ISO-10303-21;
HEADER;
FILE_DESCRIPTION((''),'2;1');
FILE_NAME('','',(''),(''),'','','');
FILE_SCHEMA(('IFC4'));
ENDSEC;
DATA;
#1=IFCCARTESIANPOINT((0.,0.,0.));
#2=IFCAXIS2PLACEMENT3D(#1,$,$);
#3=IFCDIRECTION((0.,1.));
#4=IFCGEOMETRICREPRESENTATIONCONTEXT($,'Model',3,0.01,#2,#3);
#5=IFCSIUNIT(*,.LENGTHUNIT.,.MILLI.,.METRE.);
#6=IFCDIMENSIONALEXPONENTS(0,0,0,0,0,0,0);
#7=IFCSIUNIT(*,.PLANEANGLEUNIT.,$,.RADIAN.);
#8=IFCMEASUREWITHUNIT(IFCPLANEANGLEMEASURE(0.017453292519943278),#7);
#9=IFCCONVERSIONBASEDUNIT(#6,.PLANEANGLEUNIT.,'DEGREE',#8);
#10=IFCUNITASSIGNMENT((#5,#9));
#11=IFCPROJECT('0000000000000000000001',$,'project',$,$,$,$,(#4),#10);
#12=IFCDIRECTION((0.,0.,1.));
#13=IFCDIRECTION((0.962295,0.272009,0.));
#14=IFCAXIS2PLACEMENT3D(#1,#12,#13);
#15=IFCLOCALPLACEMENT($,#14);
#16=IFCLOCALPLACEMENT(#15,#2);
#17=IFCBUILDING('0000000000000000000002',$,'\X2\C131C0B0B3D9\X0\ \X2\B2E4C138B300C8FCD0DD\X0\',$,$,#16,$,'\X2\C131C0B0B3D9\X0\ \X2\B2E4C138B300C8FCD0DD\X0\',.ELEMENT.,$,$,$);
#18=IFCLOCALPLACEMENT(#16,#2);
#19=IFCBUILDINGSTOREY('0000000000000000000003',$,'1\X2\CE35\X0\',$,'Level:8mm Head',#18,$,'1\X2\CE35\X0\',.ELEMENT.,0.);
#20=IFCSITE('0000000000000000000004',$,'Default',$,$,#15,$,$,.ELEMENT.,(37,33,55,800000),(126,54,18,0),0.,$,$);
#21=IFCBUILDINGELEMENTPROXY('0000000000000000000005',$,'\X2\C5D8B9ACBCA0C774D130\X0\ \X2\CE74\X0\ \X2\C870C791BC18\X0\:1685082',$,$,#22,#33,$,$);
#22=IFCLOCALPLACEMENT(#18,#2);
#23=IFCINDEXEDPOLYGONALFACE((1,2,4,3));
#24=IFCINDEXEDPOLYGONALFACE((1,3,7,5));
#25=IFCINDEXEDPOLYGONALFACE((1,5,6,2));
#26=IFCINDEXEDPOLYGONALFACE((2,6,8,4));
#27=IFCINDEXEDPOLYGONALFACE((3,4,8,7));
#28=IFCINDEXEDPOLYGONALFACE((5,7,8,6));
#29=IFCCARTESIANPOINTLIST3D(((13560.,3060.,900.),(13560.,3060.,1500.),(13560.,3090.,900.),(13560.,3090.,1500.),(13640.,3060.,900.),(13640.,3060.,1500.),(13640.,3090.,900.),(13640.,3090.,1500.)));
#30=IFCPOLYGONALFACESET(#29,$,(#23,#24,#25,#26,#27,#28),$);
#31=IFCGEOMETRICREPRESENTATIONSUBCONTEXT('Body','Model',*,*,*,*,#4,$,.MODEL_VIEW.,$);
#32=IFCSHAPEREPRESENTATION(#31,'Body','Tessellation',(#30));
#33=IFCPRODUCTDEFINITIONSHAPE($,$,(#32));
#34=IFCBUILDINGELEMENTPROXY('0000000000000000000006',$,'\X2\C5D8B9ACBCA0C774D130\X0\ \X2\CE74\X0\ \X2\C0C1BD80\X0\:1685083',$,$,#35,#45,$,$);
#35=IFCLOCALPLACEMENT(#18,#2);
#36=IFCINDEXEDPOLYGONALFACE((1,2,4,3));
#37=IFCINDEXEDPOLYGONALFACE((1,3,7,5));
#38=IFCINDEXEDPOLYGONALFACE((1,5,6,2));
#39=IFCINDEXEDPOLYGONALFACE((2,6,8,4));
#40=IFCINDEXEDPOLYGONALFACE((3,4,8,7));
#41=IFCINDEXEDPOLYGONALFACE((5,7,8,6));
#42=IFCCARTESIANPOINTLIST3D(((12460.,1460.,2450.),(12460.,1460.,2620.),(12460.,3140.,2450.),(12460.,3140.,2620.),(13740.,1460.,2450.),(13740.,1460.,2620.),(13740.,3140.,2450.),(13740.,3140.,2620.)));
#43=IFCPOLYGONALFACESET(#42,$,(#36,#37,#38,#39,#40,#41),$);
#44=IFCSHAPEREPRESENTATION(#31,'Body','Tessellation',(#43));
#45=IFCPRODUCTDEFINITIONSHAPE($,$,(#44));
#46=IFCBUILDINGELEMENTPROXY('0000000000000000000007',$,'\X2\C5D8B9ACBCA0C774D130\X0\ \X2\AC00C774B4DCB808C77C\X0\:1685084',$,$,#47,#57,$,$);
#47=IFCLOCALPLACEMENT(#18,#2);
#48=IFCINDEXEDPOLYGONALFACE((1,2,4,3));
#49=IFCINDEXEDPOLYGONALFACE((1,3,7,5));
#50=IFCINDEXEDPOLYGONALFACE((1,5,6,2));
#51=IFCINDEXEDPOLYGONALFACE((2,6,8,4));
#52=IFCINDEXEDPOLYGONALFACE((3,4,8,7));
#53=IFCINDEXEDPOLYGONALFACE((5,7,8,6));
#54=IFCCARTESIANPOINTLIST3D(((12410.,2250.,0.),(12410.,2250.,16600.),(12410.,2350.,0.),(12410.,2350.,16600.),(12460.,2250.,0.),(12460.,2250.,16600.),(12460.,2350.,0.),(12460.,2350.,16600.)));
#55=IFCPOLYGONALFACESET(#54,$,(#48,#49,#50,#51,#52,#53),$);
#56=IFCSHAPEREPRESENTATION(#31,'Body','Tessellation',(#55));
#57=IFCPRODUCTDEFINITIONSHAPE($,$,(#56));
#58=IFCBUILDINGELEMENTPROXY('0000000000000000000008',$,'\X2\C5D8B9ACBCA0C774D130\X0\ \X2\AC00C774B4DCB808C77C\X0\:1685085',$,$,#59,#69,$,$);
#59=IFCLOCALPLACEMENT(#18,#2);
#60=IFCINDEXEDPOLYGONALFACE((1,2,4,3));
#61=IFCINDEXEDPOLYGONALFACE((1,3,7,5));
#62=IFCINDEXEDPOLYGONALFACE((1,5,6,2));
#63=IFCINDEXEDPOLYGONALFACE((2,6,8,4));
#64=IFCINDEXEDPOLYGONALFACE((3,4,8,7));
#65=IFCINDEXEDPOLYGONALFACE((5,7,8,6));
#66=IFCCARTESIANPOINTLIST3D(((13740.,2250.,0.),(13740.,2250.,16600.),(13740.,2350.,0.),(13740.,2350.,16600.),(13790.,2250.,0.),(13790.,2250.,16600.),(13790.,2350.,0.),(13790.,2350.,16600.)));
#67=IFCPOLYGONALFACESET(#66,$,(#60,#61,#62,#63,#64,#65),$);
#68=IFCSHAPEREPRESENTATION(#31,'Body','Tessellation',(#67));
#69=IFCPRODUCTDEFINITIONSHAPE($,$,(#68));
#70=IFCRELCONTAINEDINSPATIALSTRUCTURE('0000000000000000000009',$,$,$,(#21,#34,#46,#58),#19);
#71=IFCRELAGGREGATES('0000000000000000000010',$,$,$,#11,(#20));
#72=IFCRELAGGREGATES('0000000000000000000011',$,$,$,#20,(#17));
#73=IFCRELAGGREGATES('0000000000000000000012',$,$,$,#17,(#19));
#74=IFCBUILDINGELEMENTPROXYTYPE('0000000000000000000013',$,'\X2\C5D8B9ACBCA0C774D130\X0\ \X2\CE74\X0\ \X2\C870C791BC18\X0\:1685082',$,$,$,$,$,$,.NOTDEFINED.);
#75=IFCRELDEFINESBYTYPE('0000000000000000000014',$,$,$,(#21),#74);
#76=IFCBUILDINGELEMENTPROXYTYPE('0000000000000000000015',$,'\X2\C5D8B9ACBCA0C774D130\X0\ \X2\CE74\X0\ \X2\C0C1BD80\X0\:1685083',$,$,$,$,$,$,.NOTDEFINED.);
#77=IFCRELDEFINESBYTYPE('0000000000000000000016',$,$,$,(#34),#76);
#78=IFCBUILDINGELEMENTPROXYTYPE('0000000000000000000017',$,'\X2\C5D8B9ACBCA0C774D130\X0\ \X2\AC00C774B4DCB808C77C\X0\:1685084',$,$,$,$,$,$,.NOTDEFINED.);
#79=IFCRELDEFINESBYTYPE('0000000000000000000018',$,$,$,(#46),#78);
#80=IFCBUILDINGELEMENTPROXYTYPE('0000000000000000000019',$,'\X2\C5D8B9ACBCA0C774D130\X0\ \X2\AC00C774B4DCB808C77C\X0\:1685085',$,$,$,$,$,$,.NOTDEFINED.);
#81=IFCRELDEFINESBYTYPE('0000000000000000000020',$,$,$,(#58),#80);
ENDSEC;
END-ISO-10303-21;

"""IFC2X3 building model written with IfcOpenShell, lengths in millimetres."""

from ifc_helpers import new_model, entity, si_unit, converted_unit, direction, frame, frame_2d, origin, origin_2d_with_axis, place, context, subcontext, project, spatial, rectangle, extrude, type_object, element, save


model = new_model("IFC2X3")

# Units and contexts
model_context = context("Model", 3, precision=0.01, world=origin(), true_north=direction((0.0, 1.0)))
body_context = subcontext(model_context, "Body", "Model", "MODEL_VIEW")
ifc_project = project(units=[si_unit("LENGTHUNIT", "METRE", prefix="MILLI"), converted_unit("PLANEANGLEUNIT", "DEGREE", entity("IfcPlaneAngleMeasure", 0.017453292519943278), si_unit("PLANEANGLEUNIT", "RADIAN"), dimensions=[0, 0, 0, 0, 0, 0, 0])], contexts=[model_context])

# Site, building, storey
site_placement = place(None, frame((0.0, 0.0, 0.0), z_axis=(0.0, 0.0, 1.0), x_axis=(0.962295, 0.272009, 0.0)))
site = spatial("IfcSite", under=ifc_project, at=site_placement, Name="Default", CompositionType="ELEMENT", RefLatitude=(37, 33, 55, 800000), RefLongitude=(126, 54, 18, 0), RefElevation=0.0)
building_placement = place(site_placement, origin())
building = spatial("IfcBuilding", under=site, at=building_placement, Name="성산동 다세대주택", LongName="성산동 다세대주택", CompositionType="ELEMENT")
storey_placement = place(building_placement, origin())
storey = spatial("IfcBuildingStorey", under=building, at=storey_placement, Name="1층", ObjectType="Level:8mm Head", LongName="1층", CompositionType="ELEMENT", Elevation=0.0)

# Building element proxies
building_element_proxy_type_1 = type_object("IfcBuildingElementProxyType", Name="엘리베이터 카 조작반:1685082", PredefinedType="NOTDEFINED")
proxy_1_placement = place(storey_placement, origin())
element("IfcBuildingElementProxy", 1, at=proxy_1_placement, inside=storey, type_object=building_element_proxy_type_1, Name="엘리베이터 카 조작반:1685082", context=body_context, shape_type="SweptSolid", body=[
    extrude(rectangle(XDim=80.0, YDim=30.0, at=frame_2d((0.0, 0.0), x_axis=(1.0, 0.0))), frame((13600.0, 3075.0, 900.0)), (0.0, 0.0, 1.0), 600.0),
])
building_element_proxy_type_2 = type_object("IfcBuildingElementProxyType", Name="엘리베이터 카 상부:1685083", PredefinedType="NOTDEFINED")
proxy_2_placement = place(storey_placement, origin())
element("IfcBuildingElementProxy", 2, at=proxy_2_placement, inside=storey, type_object=building_element_proxy_type_2, Name="엘리베이터 카 상부:1685083", context=body_context, shape_type="SweptSolid", body=[
    extrude(rectangle(XDim=1280.0, YDim=1680.0, at=origin_2d_with_axis()), frame((13100.0, 2300.0, 2450.0)), (0.0, 0.0, 1.0), 170.0),
])
building_element_proxy_type_3 = type_object("IfcBuildingElementProxyType", Name="엘리베이터 가이드레일:1685084", PredefinedType="NOTDEFINED")
proxy_3_placement = place(storey_placement, origin())
element("IfcBuildingElementProxy", 3, at=proxy_3_placement, inside=storey, type_object=building_element_proxy_type_3, Name="엘리베이터 가이드레일:1685084", context=body_context, shape_type="SweptSolid", body=[
    extrude(rectangle(XDim=50.0, YDim=100.0, at=frame_2d((0.0, 0.0), x_axis=(1.0, 0.0))), frame((12435.0, 2300.0, 0.0)), (0.0, 0.0, 1.0), 16600.0),
])
building_element_proxy_type_4 = type_object("IfcBuildingElementProxyType", Name="엘리베이터 가이드레일:1685085", PredefinedType="NOTDEFINED")
proxy_4_placement = place(storey_placement, origin())
element("IfcBuildingElementProxy", 4, at=proxy_4_placement, inside=storey, type_object=building_element_proxy_type_4, Name="엘리베이터 가이드레일:1685085", context=body_context, shape_type="SweptSolid", body=[
    extrude(rectangle(XDim=50.0, YDim=100.0, at=frame_2d((0.0, 0.0), x_axis=(1.0, 0.0))), frame((13765.0, 2300.0, 0.0)), (0.0, 0.0, 1.0), 16600.0),
])

save(model, "model.ifc")
